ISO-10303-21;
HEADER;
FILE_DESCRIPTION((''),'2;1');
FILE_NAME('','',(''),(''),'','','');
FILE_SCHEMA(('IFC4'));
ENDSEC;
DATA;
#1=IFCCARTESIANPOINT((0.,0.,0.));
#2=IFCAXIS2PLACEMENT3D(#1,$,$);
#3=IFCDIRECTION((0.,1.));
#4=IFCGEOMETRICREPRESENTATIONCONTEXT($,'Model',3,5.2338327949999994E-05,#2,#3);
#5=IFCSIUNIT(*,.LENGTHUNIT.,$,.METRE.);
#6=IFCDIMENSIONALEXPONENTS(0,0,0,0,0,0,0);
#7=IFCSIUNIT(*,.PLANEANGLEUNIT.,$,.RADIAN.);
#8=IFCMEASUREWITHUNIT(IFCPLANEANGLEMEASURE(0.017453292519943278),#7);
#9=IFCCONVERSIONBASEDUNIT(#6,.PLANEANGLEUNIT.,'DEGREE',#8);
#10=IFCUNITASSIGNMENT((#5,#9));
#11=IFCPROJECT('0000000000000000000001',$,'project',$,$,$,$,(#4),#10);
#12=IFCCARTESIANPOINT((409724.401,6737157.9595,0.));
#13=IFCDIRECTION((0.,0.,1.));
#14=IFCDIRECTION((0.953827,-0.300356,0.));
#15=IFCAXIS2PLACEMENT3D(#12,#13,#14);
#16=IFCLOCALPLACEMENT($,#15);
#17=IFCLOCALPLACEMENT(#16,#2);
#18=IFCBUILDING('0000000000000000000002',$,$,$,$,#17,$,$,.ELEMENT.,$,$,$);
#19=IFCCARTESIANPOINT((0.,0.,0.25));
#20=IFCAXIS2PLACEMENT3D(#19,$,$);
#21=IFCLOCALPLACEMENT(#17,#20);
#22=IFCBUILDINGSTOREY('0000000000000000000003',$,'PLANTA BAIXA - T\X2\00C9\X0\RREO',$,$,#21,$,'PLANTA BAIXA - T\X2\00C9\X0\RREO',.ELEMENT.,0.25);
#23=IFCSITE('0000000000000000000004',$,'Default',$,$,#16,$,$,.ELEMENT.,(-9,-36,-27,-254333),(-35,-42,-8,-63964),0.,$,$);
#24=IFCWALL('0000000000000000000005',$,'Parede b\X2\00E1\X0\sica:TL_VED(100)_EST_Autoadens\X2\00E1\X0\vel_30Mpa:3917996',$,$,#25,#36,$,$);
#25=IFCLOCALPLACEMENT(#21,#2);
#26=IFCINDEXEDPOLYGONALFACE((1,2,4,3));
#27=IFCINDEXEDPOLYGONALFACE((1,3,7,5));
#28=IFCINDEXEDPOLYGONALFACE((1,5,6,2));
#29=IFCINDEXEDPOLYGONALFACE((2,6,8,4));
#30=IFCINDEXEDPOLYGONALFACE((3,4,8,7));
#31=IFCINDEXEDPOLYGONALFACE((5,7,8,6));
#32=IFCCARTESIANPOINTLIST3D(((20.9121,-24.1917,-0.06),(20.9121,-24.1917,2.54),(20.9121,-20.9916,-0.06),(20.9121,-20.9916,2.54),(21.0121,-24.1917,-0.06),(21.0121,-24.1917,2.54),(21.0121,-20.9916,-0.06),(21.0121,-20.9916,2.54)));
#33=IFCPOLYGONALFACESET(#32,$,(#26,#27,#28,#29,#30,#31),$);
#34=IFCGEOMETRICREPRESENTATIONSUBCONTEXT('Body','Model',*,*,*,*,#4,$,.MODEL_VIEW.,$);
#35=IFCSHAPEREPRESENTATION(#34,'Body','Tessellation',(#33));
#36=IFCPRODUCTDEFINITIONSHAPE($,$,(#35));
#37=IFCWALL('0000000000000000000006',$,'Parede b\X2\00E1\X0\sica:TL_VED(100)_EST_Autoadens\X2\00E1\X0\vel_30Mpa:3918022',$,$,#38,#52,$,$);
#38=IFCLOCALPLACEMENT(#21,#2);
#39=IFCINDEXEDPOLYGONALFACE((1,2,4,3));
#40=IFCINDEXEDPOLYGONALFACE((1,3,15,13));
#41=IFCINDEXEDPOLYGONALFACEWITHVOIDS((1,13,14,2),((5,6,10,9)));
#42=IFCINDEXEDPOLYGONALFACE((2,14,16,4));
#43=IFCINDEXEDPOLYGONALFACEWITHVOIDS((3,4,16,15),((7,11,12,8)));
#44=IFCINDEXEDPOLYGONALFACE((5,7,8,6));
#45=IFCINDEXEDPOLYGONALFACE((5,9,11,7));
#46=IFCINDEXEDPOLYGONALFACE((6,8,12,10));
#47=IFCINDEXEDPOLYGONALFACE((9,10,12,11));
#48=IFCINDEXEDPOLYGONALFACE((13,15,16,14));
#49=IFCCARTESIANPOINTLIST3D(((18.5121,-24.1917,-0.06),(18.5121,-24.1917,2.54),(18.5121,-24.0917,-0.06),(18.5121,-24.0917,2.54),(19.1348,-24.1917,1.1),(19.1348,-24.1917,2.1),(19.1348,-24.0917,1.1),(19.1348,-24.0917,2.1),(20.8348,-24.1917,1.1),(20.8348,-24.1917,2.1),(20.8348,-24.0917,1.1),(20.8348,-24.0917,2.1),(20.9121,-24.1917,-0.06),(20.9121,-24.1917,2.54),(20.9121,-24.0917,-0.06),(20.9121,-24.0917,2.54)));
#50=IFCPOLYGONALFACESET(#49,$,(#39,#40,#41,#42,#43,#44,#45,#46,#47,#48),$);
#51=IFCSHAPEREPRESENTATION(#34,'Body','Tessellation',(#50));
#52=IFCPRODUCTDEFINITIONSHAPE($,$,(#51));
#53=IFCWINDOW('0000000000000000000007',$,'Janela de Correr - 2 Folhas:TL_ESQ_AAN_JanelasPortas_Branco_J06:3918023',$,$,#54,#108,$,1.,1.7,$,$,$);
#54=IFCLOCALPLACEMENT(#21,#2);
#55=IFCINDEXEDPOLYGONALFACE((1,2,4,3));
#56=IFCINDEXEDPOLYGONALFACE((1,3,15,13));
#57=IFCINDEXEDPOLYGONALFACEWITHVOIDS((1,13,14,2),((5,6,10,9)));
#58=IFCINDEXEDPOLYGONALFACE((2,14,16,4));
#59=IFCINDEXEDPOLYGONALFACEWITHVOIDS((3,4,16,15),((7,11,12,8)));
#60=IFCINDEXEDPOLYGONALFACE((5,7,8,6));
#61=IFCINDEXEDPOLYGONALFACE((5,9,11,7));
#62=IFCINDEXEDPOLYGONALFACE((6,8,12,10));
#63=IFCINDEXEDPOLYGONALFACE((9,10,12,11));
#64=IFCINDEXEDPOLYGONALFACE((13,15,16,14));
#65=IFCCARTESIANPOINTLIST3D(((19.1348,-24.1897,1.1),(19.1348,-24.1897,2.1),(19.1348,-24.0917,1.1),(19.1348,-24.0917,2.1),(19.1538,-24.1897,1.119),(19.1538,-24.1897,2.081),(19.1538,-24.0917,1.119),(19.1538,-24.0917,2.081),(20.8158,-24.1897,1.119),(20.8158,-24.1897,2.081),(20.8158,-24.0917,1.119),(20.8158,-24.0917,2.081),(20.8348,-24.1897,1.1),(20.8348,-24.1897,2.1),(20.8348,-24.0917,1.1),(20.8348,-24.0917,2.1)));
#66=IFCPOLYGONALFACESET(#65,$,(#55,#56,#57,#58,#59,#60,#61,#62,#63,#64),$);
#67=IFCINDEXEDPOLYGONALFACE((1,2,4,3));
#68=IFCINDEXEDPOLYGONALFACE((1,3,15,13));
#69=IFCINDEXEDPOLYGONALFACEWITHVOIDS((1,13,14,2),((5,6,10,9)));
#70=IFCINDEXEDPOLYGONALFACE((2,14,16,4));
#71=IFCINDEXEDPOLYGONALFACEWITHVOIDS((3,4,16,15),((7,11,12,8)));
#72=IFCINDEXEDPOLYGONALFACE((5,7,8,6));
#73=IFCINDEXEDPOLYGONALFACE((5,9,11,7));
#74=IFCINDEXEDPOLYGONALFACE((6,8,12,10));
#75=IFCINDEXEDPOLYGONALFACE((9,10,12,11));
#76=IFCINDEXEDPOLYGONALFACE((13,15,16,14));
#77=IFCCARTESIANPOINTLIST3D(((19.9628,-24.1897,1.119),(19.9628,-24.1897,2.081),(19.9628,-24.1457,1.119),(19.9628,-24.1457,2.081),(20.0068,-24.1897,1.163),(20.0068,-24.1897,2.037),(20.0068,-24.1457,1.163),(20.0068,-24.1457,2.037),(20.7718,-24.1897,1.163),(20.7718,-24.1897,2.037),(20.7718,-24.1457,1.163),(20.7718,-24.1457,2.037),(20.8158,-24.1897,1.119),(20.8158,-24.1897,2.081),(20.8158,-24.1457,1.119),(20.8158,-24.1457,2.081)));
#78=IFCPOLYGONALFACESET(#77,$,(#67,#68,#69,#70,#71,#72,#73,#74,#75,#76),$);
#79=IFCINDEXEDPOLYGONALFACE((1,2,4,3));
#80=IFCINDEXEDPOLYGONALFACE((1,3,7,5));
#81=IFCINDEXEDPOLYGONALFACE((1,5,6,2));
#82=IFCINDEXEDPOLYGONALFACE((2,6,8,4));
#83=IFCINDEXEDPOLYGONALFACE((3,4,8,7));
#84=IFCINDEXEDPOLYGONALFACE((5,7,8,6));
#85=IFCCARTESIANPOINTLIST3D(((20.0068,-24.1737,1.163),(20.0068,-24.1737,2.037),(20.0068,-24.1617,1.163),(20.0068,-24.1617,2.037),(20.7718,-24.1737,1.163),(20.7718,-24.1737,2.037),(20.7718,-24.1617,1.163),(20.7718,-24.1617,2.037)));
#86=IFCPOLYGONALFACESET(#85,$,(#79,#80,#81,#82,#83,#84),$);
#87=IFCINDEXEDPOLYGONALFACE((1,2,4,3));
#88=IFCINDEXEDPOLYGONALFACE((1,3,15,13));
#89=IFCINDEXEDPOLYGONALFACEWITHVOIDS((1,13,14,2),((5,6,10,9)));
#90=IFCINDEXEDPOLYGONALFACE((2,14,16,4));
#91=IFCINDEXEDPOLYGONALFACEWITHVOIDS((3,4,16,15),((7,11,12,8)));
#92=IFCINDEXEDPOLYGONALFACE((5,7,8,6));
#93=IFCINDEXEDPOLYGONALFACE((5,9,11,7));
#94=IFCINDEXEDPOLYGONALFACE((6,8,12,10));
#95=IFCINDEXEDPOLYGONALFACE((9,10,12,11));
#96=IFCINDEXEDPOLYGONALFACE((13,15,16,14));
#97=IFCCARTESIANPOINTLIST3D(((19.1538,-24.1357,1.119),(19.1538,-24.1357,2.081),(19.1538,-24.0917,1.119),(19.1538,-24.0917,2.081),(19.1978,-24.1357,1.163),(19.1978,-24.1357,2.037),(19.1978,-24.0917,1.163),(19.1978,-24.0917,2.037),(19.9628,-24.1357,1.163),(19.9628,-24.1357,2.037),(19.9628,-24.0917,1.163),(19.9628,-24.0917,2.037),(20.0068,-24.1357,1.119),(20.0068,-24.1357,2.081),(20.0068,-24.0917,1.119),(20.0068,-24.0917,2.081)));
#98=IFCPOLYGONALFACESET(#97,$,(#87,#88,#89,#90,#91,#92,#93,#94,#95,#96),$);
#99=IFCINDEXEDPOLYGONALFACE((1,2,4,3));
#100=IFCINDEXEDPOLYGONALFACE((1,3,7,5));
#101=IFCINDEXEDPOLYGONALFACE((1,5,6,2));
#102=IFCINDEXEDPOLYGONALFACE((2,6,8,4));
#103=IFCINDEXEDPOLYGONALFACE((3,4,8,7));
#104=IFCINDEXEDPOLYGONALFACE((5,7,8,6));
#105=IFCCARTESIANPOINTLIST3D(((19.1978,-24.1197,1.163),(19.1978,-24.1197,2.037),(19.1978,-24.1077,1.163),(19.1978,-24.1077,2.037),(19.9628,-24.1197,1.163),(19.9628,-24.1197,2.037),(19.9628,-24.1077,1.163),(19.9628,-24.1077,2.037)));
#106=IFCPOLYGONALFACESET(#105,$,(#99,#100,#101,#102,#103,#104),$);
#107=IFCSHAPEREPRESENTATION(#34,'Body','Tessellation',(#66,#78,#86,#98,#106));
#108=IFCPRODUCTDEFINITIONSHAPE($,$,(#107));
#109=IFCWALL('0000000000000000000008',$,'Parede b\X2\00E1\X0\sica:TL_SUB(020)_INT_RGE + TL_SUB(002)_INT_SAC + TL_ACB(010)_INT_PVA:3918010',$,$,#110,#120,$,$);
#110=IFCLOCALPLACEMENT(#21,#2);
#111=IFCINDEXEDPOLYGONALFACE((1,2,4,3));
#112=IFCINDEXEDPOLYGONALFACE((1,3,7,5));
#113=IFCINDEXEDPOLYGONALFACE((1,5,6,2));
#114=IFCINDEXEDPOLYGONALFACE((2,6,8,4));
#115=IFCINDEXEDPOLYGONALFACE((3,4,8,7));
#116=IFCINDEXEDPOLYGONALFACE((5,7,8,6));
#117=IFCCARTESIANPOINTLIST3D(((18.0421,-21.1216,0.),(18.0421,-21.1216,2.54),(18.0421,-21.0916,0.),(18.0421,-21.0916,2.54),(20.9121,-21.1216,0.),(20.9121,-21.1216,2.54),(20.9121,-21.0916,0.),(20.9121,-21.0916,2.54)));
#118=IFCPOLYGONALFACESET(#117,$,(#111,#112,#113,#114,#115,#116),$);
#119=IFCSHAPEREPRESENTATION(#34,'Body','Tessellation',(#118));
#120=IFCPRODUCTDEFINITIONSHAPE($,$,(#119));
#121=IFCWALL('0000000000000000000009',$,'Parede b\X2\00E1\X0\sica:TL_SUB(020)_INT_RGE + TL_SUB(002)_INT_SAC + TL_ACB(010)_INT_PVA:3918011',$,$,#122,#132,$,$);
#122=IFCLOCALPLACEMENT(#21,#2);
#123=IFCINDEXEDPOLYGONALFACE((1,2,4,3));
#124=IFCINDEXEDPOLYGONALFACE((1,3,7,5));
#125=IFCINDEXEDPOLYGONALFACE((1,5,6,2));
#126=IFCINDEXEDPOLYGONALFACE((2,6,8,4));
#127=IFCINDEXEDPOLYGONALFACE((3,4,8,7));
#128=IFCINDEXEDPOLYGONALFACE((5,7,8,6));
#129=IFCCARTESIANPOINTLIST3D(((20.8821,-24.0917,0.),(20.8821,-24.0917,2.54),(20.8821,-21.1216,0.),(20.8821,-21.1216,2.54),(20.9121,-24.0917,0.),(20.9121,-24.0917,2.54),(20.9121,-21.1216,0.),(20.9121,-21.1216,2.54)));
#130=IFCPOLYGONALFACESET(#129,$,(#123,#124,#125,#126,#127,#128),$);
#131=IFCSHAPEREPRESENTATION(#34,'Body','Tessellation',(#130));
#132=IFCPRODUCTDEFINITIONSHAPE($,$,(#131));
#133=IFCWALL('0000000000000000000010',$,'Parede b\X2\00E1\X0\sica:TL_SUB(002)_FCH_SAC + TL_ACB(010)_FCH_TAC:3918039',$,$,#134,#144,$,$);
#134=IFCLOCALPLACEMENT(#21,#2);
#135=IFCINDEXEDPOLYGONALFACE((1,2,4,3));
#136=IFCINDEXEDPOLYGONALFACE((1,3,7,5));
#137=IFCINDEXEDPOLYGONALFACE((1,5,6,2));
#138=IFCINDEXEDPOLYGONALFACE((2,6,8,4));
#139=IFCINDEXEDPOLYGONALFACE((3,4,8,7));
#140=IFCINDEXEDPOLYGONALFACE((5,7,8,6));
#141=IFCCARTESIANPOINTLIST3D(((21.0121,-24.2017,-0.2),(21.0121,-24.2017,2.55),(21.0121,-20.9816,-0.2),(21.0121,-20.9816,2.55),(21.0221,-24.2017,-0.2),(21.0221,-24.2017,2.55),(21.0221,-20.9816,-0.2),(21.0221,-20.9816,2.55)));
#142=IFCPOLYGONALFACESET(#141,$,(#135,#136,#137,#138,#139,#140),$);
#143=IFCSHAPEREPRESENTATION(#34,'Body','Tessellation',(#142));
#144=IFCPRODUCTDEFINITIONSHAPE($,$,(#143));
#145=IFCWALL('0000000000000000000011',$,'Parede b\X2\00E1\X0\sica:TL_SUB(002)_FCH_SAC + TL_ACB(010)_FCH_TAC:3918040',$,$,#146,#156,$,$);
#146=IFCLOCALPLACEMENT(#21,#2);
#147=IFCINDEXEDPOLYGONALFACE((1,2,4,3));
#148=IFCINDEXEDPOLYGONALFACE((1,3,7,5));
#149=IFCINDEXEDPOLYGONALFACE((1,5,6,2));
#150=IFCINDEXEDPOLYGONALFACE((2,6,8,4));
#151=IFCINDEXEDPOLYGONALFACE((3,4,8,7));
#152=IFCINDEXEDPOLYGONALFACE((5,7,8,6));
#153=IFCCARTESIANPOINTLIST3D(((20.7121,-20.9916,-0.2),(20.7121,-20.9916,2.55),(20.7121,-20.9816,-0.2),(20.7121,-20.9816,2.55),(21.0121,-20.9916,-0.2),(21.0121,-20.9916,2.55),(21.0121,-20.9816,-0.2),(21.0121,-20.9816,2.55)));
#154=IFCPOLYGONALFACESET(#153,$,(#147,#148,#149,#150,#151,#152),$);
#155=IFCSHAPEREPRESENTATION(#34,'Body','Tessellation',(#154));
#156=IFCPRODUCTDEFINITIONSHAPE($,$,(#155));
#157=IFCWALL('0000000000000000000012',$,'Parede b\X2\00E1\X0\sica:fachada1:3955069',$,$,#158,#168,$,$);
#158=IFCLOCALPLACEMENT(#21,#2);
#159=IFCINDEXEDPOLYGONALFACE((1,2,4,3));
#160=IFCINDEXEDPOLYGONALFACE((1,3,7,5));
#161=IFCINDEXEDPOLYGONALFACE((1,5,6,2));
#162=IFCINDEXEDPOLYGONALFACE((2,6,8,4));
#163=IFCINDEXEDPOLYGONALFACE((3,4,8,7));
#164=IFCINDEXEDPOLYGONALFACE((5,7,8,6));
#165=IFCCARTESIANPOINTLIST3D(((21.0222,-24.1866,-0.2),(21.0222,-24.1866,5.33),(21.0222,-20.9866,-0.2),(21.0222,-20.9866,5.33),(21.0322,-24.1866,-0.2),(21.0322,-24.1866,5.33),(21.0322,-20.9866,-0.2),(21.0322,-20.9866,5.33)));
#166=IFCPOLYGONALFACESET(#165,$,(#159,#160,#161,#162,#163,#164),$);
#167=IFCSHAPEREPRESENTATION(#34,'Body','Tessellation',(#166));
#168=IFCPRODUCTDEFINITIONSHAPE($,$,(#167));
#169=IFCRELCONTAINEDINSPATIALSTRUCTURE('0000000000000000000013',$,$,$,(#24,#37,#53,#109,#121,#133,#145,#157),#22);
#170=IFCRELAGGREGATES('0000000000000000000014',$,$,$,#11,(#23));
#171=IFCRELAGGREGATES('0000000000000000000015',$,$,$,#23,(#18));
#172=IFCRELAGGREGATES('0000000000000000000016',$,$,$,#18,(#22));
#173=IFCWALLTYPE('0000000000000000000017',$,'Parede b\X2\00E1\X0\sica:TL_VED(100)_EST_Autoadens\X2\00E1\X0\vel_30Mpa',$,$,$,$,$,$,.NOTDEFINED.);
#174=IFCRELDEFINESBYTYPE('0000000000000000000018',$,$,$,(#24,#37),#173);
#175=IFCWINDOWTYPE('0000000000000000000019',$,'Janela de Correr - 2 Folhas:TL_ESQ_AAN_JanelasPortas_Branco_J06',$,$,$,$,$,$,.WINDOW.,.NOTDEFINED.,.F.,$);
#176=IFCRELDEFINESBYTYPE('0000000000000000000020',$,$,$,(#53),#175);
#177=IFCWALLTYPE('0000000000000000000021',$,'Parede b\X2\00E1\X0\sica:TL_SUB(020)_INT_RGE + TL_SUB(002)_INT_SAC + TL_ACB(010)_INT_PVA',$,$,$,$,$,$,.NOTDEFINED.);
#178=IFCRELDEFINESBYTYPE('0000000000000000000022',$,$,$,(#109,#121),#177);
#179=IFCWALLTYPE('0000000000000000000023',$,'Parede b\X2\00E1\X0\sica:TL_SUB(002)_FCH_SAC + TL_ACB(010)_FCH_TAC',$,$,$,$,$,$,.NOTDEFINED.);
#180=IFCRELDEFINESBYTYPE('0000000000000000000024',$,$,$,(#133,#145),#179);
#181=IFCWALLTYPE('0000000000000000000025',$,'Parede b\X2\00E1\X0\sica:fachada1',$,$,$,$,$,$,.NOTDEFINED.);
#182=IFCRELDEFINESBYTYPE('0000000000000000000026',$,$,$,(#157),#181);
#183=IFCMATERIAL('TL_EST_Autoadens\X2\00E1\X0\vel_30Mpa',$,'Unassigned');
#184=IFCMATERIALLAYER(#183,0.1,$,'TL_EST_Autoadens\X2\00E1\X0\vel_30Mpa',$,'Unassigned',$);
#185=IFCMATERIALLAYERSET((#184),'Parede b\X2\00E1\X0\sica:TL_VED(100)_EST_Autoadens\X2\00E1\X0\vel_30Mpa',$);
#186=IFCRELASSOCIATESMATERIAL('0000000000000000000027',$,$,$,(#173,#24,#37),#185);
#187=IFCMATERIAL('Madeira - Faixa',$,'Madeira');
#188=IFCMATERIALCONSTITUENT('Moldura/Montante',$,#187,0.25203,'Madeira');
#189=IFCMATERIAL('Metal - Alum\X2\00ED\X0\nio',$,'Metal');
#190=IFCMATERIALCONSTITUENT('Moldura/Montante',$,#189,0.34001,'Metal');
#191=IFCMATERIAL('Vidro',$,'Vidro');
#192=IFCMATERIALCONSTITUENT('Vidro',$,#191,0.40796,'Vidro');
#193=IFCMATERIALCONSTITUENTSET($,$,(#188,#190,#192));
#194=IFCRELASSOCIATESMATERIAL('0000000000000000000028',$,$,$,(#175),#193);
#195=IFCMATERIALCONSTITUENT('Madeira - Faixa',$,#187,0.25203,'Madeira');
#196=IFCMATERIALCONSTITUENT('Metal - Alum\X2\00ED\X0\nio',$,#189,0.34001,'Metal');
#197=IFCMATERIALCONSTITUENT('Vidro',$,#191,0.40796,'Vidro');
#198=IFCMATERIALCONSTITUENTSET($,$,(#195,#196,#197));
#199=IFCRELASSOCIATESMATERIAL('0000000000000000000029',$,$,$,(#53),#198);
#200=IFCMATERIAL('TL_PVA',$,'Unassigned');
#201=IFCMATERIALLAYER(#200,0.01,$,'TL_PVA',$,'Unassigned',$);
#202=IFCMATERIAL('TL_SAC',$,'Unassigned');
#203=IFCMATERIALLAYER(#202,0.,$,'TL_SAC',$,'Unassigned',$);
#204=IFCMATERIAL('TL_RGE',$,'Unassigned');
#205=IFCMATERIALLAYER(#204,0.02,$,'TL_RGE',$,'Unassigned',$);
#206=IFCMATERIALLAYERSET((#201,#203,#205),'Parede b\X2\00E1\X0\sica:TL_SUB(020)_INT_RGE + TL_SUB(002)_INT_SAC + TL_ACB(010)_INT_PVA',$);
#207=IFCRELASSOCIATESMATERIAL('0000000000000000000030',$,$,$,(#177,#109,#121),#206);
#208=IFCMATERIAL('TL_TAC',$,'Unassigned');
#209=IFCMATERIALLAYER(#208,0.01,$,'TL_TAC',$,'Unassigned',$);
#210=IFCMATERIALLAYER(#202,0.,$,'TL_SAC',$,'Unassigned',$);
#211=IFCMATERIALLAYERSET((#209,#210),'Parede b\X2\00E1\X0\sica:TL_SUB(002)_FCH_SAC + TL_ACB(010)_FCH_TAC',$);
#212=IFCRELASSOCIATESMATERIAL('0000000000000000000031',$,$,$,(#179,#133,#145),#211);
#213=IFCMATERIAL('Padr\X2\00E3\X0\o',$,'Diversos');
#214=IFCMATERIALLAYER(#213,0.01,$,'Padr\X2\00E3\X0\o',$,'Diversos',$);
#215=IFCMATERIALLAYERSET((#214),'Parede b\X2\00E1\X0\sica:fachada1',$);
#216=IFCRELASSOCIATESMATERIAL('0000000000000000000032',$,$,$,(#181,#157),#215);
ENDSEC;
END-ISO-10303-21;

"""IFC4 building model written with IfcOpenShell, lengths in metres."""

from ifc_helpers import new_model, entity, si_unit, converted_unit, direction, frame, frame_2d, origin, origin_2d_with_axis, place, context, subcontext, project, spatial, polyline, rectangle, outline, extrude, source, transform, mapped, material, layer, layer_set, layer_usage, constituent, constituent_set, type_object, type_shapes, element, fill, save


model = new_model("IFC4")

# Units and contexts
model_context = context("Model", 3, precision=5.2338327949999994e-05, world=origin(), true_north=direction((0.0, 1.0)))
body_context = subcontext(model_context, "Body", "Model", "MODEL_VIEW")
ifc_project = project(units=[si_unit("LENGTHUNIT", "METRE"), converted_unit("PLANEANGLEUNIT", "DEGREE", entity("IfcPlaneAngleMeasure", 0.017453292519943278), si_unit("PLANEANGLEUNIT", "RADIAN"), dimensions=[0, 0, 0, 0, 0, 0, 0])], contexts=[model_context])

# Site, building, storey
site_placement = place(None, frame((409724.401, 6737157.9595, 0.0), z_axis=(0.0, 0.0, 1.0), x_axis=(0.953827, -0.300356, 0.0)))
site = spatial("IfcSite", under=ifc_project, at=site_placement, Name="Default", CompositionType="ELEMENT", RefLatitude=(-9, -36, -27, -254333), RefLongitude=(-35, -42, -8, -63964), RefElevation=0.0)
building_placement = place(site_placement, origin())
building = spatial("IfcBuilding", under=site, at=building_placement, CompositionType="ELEMENT")
storey_placement = place(building_placement, frame((0.0, 0.0, 0.25)))
storey = spatial("IfcBuildingStorey", under=building, at=storey_placement, Name="PLANTA BAIXA - TÉRREO", LongName="PLANTA BAIXA - TÉRREO", CompositionType="ELEMENT", Elevation=0.25)

# Wall
ifc_material_1 = material(Name="TL_EST_Autoadensável_30Mpa", Category="Unassigned")
ifc_layer_1 = layer(ifc_material_1, 0.1, Name="TL_EST_Autoadensável_30Mpa", Category="Unassigned")
ifc_layer_set_1 = layer_set([ifc_layer_1], Name="Parede básica:TL_VED(100)_EST_Autoadensável_30Mpa")
ifc_layer_usage_1 = layer_usage(ifc_layer_set_1, "AXIS2", "NEGATIVE", 0.05)
wall_type_1 = type_object("IfcWallType", Name="Parede básica:TL_VED(100)_EST_Autoadensável_30Mpa", PredefinedType="NOTDEFINED", material=ifc_layer_set_1)
wall_1_placement = place(storey_placement, frame((20.9621, -24.1917, -0.06), z_axis=(0.0, 0.0, 1.0), x_axis=(0.0, 1.0, 0.0)))
element("IfcWall", 1, at=wall_1_placement, inside=storey, type_object=wall_type_1, material=ifc_layer_usage_1, Name="Parede básica:TL_VED(100)_EST_Autoadensável_30Mpa:3917996", context=body_context, shape_type="SweptSolid", body=[
    extrude(rectangle(XDim=3.2001, YDim=0.1, at=frame_2d((1.6001, 0.0), x_axis=(-1.0, 0.0))), origin(), (0.0, 0.0, 1.0), 2.6),
])

# Wall, opening, window
ifc_layer_usage_2 = layer_usage(ifc_layer_set_1, "AXIS2", "NEGATIVE", 0.05)
wall_2_placement = place(storey_placement, frame((20.9121, -24.1417, -0.06), z_axis=(0.0, 0.0, 1.0), x_axis=(-1.0, 0.0, 0.0)))
wall_2 = element("IfcWall", 2, at=wall_2_placement, inside=storey, type_object=wall_type_1, material=ifc_layer_usage_2, Name="Parede básica:TL_VED(100)_EST_Autoadensável_30Mpa:3918022", context=body_context, shape_type="SweptSolid", body=[
    extrude(rectangle(XDim=2.4, YDim=0.1, at=frame_2d((1.2, 0.0), x_axis=(-1.0, 0.0))), origin(), (0.0, 0.0, 1.0), 2.6),
])
opening_placement = place(wall_2_placement, frame((0.0774, -0.05, 1.16)))
opening = element("IfcOpeningElement", 3, at=opening_placement, cuts=wall_2, PredefinedType="OPENING", context=body_context, shape_type="SweptSolid", body=[
    extrude(rectangle(XDim=1.0, YDim=1.7, at=frame_2d((0.5, 0.85), x_axis=(-1.0, 0.0))), frame((0.0, 0.0, 0.0), z_axis=(0.0, 1.0, 0.0), x_axis=(0.0, 0.0, 1.0)), (0.0, 0.0, 1.0), 0.1),
])
ifc_material_2 = material(Name="Madeira - Faixa", Category="Madeira")
ifc_constituent_1 = constituent(ifc_material_2, Name="Madeira - Faixa", Category="Madeira", fraction=0.25203)
ifc_material_3 = material(Name="Metal - Alumínio", Category="Metal")
ifc_constituent_2 = constituent(ifc_material_3, Name="Metal - Alumínio", Category="Metal", fraction=0.34001)
ifc_material_4 = material(Name="Vidro", Category="Vidro")
ifc_constituent_3 = constituent(ifc_material_4, Name="Vidro", Category="Vidro", fraction=0.40796)
ifc_constituent_set_1 = constituent_set(constituents=[ifc_constituent_1, ifc_constituent_2, ifc_constituent_3])
ifc_constituent_4 = constituent(ifc_material_2, Name="Moldura/Montante", Category="Madeira", fraction=0.25203)
ifc_constituent_5 = constituent(ifc_material_3, Name="Moldura/Montante", Category="Metal", fraction=0.34001)
ifc_constituent_6 = constituent(ifc_material_4, Name="Vidro", Category="Vidro", fraction=0.40796)
ifc_constituent_set_2 = constituent_set(constituents=[ifc_constituent_4, ifc_constituent_5, ifc_constituent_6])
window_type = type_object("IfcWindowType", Name="Janela de Correr - 2 Folhas:TL_ESQ_AAN_JanelasPortas_Branco_J06", ParameterTakesPrecedence=False, PartitioningType="NOTDEFINED", PredefinedType="WINDOW", material=ifc_constituent_set_2)
shared_shape_1 = source(origin(), body_context, "Body", "SweptSolid", [
    extrude(outline(polyline([(-0.85, -0.5), (0.85, -0.5), (0.85, 0.5), (-0.85, 0.5), (-0.85, -0.5)]), holes=[polyline([(-0.831, -0.481), (-0.831, 0.481), (0.831, 0.481), (0.831, -0.481), (-0.831, -0.481)])]), frame((0.85, 0.124, 0.5), z_axis=(0.0, -1.0, 0.0), x_axis=(-1.0, 0.0, 0.0)), (0.0, 0.0, 1.0), 0.098),
    extrude(outline(polyline([(-0.4265, -0.481), (0.4265, -0.481), (0.4265, 0.481), (-0.4265, 0.481), (-0.4265, -0.481)]), holes=[polyline([(-0.3825, -0.437), (-0.3825, 0.437), (0.3825, 0.437), (0.3825, -0.437), (-0.3825, -0.437)])]), frame((0.4455, 0.124, 0.5), z_axis=(0.0, -1.0, 0.0), x_axis=(-1.0, 0.0, 0.0)), (0.0, 0.0, 1.0), 0.044),
    extrude(rectangle(XDim=0.765, YDim=0.012, at=origin_2d_with_axis()), frame((0.4455, 0.102, 0.063), z_axis=(0.0, 0.0, 1.0), x_axis=(-1.0, 0.0, 0.0)), (0.0, 0.0, 1.0), 0.874),
    extrude(outline(polyline([(-0.481, -0.4265), (0.481, -0.4265), (0.481, 0.4265), (-0.481, 0.4265), (-0.481, -0.4265)]), holes=[polyline([(-0.437, -0.3825), (-0.437, 0.3825), (0.437, 0.3825), (0.437, -0.3825), (-0.437, -0.3825)])]), frame((1.2545, 0.07, 0.5), z_axis=(0.0, -1.0, 0.0), x_axis=(0.0, 0.0, -1.0)), (0.0, 0.0, 1.0), 0.044),
    extrude(rectangle(XDim=0.765, YDim=0.012, at=origin_2d_with_axis()), frame((1.2545, 0.048, 0.063), z_axis=(0.0, 0.0, 1.0), x_axis=(-1.0, 0.0, 0.0)), (0.0, 0.0, 1.0), 0.874),
])
type_shapes(window_type, [shared_shape_1])
window_placement = place(opening_placement, frame((0.0, -0.026, 0.0)))
window = element("IfcWindow", 4, at=window_placement, inside=storey, type_object=window_type, material=ifc_constituent_set_1, Name="Janela de Correr - 2 Folhas:TL_ESQ_AAN_JanelasPortas_Branco_J06:3918023", OverallHeight=1.0, OverallWidth=1.7, context=body_context, shape_type="MappedRepresentation", body=[
    mapped(shared_shape_1, transform((0.0, 0.0, 0.0), scale=1.0)),
])
fill(opening, window)

# Walls
ifc_material_5 = material(Name="TL_PVA", Category="Unassigned")
ifc_layer_2 = layer(ifc_material_5, 0.01, Name="TL_PVA", Category="Unassigned")
ifc_material_6 = material(Name="TL_SAC", Category="Unassigned")
ifc_layer_3 = layer(ifc_material_6, 0.0, Name="TL_SAC", Category="Unassigned")
ifc_material_7 = material(Name="TL_RGE", Category="Unassigned")
ifc_layer_4 = layer(ifc_material_7, 0.02, Name="TL_RGE", Category="Unassigned")
ifc_layer_set_2 = layer_set([ifc_layer_2, ifc_layer_3, ifc_layer_4], Name="Parede básica:TL_SUB(020)_INT_RGE + TL_SUB(002)_INT_SAC + TL_ACB(010)_INT_PVA")
ifc_layer_usage_3 = layer_usage(ifc_layer_set_2, "AXIS2", "NEGATIVE", 0.015)
wall_type_2 = type_object("IfcWallType", Name="Parede básica:TL_SUB(020)_INT_RGE + TL_SUB(002)_INT_SAC + TL_ACB(010)_INT_PVA", PredefinedType="NOTDEFINED", material=ifc_layer_set_2)
wall_3_placement = place(storey_placement, frame((20.9121, -21.1066, 0.0), z_axis=(0.0, 0.0, 1.0), x_axis=(-1.0, 0.0, 0.0)))
element("IfcWall", 5, at=wall_3_placement, inside=storey, type_object=wall_type_2, material=ifc_layer_usage_3, Name="Parede básica:TL_SUB(020)_INT_RGE + TL_SUB(002)_INT_SAC + TL_ACB(010)_INT_PVA:3918010", context=body_context, shape_type="SweptSolid", body=[
    extrude(rectangle(XDim=2.87, YDim=0.03, at=frame_2d((1.435, 0.0), x_axis=(-1.0, 0.0))), origin(), (0.0, 0.0, 1.0), 2.54),
])
ifc_layer_usage_4 = layer_usage(ifc_layer_set_2, "AXIS2", "NEGATIVE", 0.015)
wall_4_placement = place(storey_placement, frame((20.8971, -24.0917, 0.0), z_axis=(0.0, 0.0, 1.0), x_axis=(0.0, 1.0, 0.0)))
element("IfcWall", 6, at=wall_4_placement, inside=storey, type_object=wall_type_2, material=ifc_layer_usage_4, Name="Parede básica:TL_SUB(020)_INT_RGE + TL_SUB(002)_INT_SAC + TL_ACB(010)_INT_PVA:3918011", context=body_context, shape_type="SweptSolid", body=[
    extrude(rectangle(XDim=2.9701, YDim=0.03, at=frame_2d((1.4851, 0.0), x_axis=(-1.0, 0.0))), origin(), (0.0, 0.0, 1.0), 2.54),
])
ifc_material_8 = material(Name="TL_TAC", Category="Unassigned")
ifc_layer_5 = layer(ifc_material_8, 0.01, Name="TL_TAC", Category="Unassigned")
ifc_layer_6 = layer(ifc_material_6, 0.0, Name="TL_SAC", Category="Unassigned")
ifc_layer_set_3 = layer_set([ifc_layer_5, ifc_layer_6], Name="Parede básica:TL_SUB(002)_FCH_SAC + TL_ACB(010)_FCH_TAC")
ifc_layer_usage_5 = layer_usage(ifc_layer_set_3, "AXIS2", "NEGATIVE", 0.005)
wall_type_3 = type_object("IfcWallType", Name="Parede básica:TL_SUB(002)_FCH_SAC + TL_ACB(010)_FCH_TAC", PredefinedType="NOTDEFINED", material=ifc_layer_set_3)
wall_5_placement = place(storey_placement, frame((21.0171, -24.2017, -0.2), z_axis=(0.0, 0.0, 1.0), x_axis=(0.0, 1.0, 0.0)))
element("IfcWall", 7, at=wall_5_placement, inside=storey, type_object=wall_type_3, material=ifc_layer_usage_5, Name="Parede básica:TL_SUB(002)_FCH_SAC + TL_ACB(010)_FCH_TAC:3918039", context=body_context, shape_type="SweptSolid", body=[
    extrude(rectangle(XDim=3.2201, YDim=0.01, at=frame_2d((1.6101, 0.0), x_axis=(-1.0, 0.0))), origin(), (0.0, 0.0, 1.0), 2.75),
])
ifc_layer_usage_6 = layer_usage(ifc_layer_set_3, "AXIS2", "NEGATIVE", 0.005)
wall_6_placement = place(storey_placement, frame((21.0121, -20.9866, -0.2), z_axis=(0.0, 0.0, 1.0), x_axis=(-1.0, 0.0, 0.0)))
element("IfcWall", 8, at=wall_6_placement, inside=storey, type_object=wall_type_3, material=ifc_layer_usage_6, Name="Parede básica:TL_SUB(002)_FCH_SAC + TL_ACB(010)_FCH_TAC:3918040", context=body_context, shape_type="SweptSolid", body=[
    extrude(rectangle(XDim=0.3, YDim=0.01, at=frame_2d((0.15, 0.0), x_axis=(-1.0, 0.0))), origin(), (0.0, 0.0, 1.0), 2.75),
])
ifc_material_9 = material(Name="Padrão", Category="Diversos")
ifc_layer_7 = layer(ifc_material_9, 0.01, Name="Padrão", Category="Diversos")
ifc_layer_set_4 = layer_set([ifc_layer_7], Name="Parede básica:fachada1")
ifc_layer_usage_7 = layer_usage(ifc_layer_set_4, "AXIS2", "POSITIVE", -0.005)
wall_type_4 = type_object("IfcWallType", Name="Parede básica:fachada1", PredefinedType="NOTDEFINED", material=ifc_layer_set_4)
wall_7_placement = place(storey_placement, frame((21.0272, -20.9866, -0.2), z_axis=(0.0, 0.0, 1.0), x_axis=(0.0, -1.0, 0.0)))
element("IfcWall", 9, at=wall_7_placement, inside=storey, type_object=wall_type_4, material=ifc_layer_usage_7, Name="Parede básica:fachada1:3955069", context=body_context, shape_type="SweptSolid", body=[
    extrude(rectangle(XDim=3.2, YDim=0.01, at=frame_2d((1.6, 0.0), x_axis=(-1.0, 0.0))), origin(), (0.0, 0.0, 1.0), 5.53),
])

save(model, "model.ifc")
